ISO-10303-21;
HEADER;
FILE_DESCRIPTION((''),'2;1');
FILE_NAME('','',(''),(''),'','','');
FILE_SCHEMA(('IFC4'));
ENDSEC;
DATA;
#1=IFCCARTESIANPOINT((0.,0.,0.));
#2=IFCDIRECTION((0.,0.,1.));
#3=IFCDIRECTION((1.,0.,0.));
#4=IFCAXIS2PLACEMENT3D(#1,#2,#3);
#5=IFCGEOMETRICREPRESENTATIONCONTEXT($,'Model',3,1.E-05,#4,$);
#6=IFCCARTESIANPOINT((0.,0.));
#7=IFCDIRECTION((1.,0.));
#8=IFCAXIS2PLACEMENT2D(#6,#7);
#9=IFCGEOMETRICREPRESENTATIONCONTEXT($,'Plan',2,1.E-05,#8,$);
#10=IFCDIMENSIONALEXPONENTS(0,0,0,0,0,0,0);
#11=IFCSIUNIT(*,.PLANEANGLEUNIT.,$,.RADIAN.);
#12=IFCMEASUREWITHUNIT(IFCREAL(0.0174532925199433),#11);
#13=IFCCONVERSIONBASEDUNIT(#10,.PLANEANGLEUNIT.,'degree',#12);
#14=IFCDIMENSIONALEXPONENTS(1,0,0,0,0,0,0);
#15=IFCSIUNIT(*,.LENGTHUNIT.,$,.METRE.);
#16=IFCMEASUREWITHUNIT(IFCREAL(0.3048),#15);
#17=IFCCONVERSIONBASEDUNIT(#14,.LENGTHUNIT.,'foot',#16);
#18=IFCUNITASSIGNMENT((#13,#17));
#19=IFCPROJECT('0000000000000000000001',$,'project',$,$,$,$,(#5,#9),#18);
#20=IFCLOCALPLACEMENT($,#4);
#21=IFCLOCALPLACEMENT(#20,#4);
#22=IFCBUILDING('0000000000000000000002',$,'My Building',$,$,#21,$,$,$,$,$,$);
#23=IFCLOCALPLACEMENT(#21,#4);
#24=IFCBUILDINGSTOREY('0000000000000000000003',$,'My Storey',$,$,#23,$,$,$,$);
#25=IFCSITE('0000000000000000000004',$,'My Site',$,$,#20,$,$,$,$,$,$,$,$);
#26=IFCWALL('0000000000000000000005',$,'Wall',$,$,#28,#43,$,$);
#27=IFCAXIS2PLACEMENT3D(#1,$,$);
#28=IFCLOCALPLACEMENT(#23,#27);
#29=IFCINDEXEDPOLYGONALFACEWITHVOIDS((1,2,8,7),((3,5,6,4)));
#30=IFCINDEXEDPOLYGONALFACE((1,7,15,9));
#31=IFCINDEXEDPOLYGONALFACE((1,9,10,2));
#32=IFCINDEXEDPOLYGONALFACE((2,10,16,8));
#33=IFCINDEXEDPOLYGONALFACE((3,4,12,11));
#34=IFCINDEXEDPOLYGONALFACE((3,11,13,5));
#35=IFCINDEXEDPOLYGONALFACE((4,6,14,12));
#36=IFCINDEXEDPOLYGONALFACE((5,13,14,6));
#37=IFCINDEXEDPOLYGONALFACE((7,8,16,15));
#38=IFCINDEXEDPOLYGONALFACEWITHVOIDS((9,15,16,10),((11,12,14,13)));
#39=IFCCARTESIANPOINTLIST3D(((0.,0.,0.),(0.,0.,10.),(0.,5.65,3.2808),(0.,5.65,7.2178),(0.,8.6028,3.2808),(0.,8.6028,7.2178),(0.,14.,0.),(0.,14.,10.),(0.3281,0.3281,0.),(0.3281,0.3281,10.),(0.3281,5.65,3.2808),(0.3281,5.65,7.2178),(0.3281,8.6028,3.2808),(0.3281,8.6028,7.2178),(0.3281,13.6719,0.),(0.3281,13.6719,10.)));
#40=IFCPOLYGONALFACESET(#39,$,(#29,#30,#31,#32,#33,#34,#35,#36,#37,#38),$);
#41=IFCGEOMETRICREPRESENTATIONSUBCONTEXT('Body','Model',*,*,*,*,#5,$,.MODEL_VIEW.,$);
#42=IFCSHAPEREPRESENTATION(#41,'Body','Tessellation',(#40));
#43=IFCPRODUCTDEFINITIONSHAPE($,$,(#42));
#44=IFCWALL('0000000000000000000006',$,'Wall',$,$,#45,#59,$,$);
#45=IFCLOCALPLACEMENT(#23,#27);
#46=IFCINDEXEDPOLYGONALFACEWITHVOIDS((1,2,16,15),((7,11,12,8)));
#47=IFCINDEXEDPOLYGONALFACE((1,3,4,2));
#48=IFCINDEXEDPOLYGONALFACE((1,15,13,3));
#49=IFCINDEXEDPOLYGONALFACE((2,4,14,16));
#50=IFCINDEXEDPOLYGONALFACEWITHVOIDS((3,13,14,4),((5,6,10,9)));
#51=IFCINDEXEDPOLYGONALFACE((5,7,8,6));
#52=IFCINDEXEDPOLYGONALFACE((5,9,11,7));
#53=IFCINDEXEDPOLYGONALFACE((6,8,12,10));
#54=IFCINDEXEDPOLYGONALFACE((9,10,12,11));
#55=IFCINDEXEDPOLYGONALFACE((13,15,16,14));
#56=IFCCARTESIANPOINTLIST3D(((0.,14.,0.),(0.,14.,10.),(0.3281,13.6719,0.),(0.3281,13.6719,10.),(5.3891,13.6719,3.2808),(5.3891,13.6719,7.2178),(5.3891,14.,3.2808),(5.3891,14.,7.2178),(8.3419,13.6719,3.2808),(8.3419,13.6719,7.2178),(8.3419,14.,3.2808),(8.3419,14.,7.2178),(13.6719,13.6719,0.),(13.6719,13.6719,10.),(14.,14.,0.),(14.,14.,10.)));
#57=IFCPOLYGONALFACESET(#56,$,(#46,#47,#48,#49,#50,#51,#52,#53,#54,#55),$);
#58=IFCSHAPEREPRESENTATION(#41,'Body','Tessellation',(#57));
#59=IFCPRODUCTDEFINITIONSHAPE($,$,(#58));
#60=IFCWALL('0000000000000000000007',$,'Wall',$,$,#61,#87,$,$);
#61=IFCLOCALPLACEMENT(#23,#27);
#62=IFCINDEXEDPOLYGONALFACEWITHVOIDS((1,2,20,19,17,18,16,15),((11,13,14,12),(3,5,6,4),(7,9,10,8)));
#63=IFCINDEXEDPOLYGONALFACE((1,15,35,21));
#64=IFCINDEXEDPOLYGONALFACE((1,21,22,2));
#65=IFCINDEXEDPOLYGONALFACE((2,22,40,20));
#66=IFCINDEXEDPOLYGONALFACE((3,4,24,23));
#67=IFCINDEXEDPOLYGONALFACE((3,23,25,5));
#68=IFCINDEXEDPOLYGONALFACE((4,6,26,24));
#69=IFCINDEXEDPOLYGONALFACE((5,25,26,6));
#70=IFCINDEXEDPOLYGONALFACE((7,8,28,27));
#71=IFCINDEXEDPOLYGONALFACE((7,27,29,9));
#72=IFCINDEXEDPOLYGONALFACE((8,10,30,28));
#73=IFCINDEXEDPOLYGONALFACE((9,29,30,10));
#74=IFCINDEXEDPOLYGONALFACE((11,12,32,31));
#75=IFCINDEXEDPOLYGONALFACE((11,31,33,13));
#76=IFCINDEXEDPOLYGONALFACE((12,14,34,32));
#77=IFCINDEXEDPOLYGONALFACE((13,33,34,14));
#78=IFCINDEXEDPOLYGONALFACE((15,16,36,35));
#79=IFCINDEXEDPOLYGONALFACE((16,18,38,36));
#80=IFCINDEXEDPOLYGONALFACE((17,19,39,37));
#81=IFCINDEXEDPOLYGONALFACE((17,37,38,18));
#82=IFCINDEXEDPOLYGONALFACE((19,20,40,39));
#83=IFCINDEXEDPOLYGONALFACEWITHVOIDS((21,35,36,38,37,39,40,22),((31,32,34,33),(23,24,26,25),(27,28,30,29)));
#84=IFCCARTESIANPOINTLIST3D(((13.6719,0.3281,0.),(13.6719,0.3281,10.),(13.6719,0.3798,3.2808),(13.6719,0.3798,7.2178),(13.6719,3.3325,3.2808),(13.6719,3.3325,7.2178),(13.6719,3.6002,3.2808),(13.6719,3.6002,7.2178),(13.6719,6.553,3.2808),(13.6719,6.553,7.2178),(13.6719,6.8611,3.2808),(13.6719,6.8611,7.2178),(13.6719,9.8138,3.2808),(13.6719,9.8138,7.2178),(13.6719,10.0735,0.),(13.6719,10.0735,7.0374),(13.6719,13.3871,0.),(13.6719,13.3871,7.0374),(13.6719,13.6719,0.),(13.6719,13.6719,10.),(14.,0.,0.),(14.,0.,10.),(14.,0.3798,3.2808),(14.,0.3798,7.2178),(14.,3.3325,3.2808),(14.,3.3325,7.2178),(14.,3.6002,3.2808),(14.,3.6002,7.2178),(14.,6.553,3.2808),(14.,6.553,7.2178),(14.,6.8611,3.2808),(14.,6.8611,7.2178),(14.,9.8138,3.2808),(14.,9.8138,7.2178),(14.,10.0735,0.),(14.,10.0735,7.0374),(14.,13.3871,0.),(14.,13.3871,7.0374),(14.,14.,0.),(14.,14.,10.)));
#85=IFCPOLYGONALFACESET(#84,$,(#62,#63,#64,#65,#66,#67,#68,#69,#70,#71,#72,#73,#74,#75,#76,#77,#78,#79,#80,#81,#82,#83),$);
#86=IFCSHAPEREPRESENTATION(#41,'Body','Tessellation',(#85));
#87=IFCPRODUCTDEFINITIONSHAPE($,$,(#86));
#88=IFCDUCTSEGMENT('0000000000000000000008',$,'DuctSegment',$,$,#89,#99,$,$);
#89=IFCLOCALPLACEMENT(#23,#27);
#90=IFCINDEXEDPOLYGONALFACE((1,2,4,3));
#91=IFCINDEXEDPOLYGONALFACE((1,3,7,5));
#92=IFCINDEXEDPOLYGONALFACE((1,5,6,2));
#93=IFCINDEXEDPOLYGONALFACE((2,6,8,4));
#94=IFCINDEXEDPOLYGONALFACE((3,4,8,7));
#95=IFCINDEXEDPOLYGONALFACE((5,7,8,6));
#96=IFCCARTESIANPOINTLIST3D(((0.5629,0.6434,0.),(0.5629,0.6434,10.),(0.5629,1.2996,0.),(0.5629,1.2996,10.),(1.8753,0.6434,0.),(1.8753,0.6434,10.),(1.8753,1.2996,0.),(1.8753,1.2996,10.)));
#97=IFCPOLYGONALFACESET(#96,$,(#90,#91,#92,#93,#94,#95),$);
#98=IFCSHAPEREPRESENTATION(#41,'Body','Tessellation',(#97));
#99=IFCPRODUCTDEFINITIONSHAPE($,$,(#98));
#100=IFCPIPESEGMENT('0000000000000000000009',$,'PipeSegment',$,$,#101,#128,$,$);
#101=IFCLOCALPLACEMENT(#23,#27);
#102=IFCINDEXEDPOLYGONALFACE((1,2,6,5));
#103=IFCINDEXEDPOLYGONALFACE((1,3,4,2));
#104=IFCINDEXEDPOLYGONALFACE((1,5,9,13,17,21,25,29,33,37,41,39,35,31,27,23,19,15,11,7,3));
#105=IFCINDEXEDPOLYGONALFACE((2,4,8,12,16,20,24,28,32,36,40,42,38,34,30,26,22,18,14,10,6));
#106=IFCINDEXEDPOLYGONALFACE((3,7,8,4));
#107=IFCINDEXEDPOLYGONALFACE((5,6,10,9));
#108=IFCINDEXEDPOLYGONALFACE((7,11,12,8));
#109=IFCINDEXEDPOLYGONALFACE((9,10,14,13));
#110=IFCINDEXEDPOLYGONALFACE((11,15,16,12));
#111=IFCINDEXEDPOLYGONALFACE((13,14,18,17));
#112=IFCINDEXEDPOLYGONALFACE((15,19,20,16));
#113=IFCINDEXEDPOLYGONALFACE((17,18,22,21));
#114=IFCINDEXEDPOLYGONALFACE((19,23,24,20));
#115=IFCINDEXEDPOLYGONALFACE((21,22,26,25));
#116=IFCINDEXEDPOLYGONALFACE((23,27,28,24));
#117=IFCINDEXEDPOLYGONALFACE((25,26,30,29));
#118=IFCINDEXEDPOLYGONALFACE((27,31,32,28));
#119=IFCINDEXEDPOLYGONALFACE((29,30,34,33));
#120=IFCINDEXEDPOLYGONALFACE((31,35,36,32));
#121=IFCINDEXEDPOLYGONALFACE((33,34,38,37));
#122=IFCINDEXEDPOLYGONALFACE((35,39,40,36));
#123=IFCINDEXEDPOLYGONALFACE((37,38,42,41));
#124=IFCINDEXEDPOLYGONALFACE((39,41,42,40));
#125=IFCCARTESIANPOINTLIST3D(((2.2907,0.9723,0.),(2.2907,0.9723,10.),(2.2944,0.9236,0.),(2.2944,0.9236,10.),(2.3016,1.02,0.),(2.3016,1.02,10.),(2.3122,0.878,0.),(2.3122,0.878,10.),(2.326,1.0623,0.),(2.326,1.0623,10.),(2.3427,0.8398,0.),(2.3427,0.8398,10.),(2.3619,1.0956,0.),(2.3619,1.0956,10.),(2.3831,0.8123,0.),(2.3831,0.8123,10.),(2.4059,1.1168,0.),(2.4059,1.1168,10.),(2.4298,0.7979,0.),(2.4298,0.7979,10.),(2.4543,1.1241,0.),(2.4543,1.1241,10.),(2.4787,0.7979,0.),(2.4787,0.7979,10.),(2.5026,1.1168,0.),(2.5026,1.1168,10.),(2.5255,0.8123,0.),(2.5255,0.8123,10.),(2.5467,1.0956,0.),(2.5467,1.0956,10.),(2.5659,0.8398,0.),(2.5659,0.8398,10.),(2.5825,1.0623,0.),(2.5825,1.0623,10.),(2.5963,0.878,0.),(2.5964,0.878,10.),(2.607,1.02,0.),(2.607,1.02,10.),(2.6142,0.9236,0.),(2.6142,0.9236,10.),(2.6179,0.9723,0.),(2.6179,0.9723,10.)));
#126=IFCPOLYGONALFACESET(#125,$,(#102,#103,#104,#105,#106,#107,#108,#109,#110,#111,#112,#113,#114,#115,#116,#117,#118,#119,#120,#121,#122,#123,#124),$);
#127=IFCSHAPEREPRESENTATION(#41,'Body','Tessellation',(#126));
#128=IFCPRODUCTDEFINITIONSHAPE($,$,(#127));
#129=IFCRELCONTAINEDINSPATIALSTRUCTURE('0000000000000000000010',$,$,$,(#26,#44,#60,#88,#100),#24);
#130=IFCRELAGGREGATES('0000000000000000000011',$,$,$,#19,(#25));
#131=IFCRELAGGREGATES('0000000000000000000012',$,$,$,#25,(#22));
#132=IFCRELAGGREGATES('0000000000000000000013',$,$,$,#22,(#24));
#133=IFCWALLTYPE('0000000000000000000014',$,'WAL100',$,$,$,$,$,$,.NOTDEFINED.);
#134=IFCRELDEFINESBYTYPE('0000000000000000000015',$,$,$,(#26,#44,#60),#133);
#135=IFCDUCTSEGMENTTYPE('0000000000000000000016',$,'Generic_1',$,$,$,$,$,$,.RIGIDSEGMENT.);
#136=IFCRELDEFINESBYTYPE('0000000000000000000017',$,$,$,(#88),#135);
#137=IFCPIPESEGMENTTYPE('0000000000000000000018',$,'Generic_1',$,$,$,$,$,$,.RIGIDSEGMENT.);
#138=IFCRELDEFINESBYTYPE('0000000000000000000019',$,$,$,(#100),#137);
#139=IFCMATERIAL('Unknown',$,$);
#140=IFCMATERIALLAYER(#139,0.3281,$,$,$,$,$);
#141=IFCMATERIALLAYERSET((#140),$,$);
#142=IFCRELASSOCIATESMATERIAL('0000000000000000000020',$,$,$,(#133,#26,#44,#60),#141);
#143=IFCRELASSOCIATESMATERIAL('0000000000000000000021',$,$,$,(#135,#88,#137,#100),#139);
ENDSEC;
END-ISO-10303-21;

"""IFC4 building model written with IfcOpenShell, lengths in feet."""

from ifc_helpers import new_model, entity, si_unit, converted_unit, frame, origin_with_axes, origin_2d_with_axis, place, context, subcontext, project, spatial, line, indexed_curve, rectangle, circle, outline, extrude, clip, halfspace, source, transform, mapped, material, layer, layer_set, layer_usage, material_profile, profile_set, profile_usage, type_object, element, save


model = new_model("IFC4")

# Units and contexts
model_context = context("Model", 3, precision=1e-05, world=origin_with_axes())
plan_context = context("Plan", 2, precision=1e-05, world=origin_2d_with_axis())
body_context_1 = subcontext(model_context, "Body", "Model", "MODEL_VIEW")
ifc_project = project(units=[converted_unit("PLANEANGLEUNIT", "degree", entity("IfcReal", 0.0174532925199433), si_unit("PLANEANGLEUNIT", "RADIAN"), dimensions=[0, 0, 0, 0, 0, 0, 0]), converted_unit("LENGTHUNIT", "foot", entity("IfcReal", 0.3048), si_unit("LENGTHUNIT", "METRE"), dimensions=[1, 0, 0, 0, 0, 0, 0])], contexts=[model_context, plan_context])

# Site, building, storey
site_placement = place(None, origin_with_axes())
site = spatial("IfcSite", under=ifc_project, at=site_placement, Name="My Site")
building_placement = place(site_placement, origin_with_axes())
building = spatial("IfcBuilding", under=site, at=building_placement, Name="My Building")
storey_placement = place(building_placement, origin_with_axes())
storey = spatial("IfcBuildingStorey", under=building, at=storey_placement, Name="My Storey")

# Shared definitions
ifc_material = material(Name="Unknown")

# Walls, openings
ifc_layer_1 = layer(ifc_material, 0.3281)
ifc_layer_set_1 = layer_set([ifc_layer_1])
wall_type = type_object("IfcWallType", Name="WAL100", PredefinedType="NOTDEFINED", material=ifc_layer_set_1)
shared_shape_1 = source(origin_with_axes(), body_context_1, "Body", "SweptSolid", [
    extrude(outline(indexed_curve([(0.0, 0.0), (2.9528, 0.0), (2.9528, 3.937), (0.0, 3.937)], segments=[line(1, 2, 3, 4, 1)])), frame((0.0, -1.9685, 0.0), z_axis=(0.0, -1.0, 0.0), x_axis=(1.0, 0.0, 0.0)), (0.0, 0.0, -1.0), 3.937),
])
ifc_layer_usage_1 = layer_usage(ifc_layer_set_1, "AXIS2", "POSITIVE", 0.0)
wall_1_placement = place(storey_placement, frame((0.0, 14.0, 0.0), z_axis=(0.0, 0.0, 1.0), x_axis=(0.0, -1.0, 0.0)))
wall_1 = element("IfcWall", 1, at=wall_1_placement, inside=storey, type_object=wall_type, material=ifc_layer_usage_1, Name="Wall", context=body_context_1, shape_type="Clipping", body=[
    clip(clip(extrude(outline(indexed_curve([(0.0, 0.0), (0.0, 0.3281), (14.0, 0.3281), (14.0, 0.0), (0.0, 0.0)], self_intersect=False)), origin_with_axes(), (0.0, 0.0, 1.0), 10.0), halfspace(frame((14.0, 0.0, 0.0), z_axis=(0.707107, 0.707107, 0.0), x_axis=(0.707107, -0.707107, 0.0)), False)), halfspace(frame((0.0, 0.0, 0.0), z_axis=(-0.707107, 0.707107, 0.0), x_axis=(0.707107, 0.707107, 0.0)), False)),
])
opening_1_placement = place(wall_1_placement, frame((5.3972, 0.0, 3.2808), z_axis=(0.0, 0.0, 1.0), x_axis=(1.0, 0.0, 0.0)))
element("IfcOpeningElement", 2, at=opening_1_placement, cuts=wall_1, PredefinedType="OPENING", context=body_context_1, shape_type="MappedRepresentation", body=[
    mapped(shared_shape_1, transform((0.0, 0.0, 0.0), x_axis=(1.0, 0.0, 0.0), y_axis=(0.0, 1.0, 0.0), z_axis=(0.0, 0.0, 1.0), scale=1.0)),
])
ifc_layer_usage_2 = layer_usage(ifc_layer_set_1, "AXIS2", "POSITIVE", 0.0)
wall_2_placement = place(storey_placement, frame((14.0, 14.0, 0.0), z_axis=(0.0, 0.0, 1.0), x_axis=(-1.0, 0.0, 0.0)))
wall_2 = element("IfcWall", 3, at=wall_2_placement, inside=storey, type_object=wall_type, material=ifc_layer_usage_2, Name="Wall", context=body_context_1, shape_type="Clipping", body=[
    clip(clip(extrude(outline(indexed_curve([(0.0, 0.0), (0.0, 0.3281), (14.0, 0.3281), (14.0, 0.0), (0.0, 0.0)], self_intersect=False)), origin_with_axes(), (0.0, 0.0, 1.0), 10.0), halfspace(frame((14.0, 0.0, 0.0), z_axis=(0.707107, 0.707107, 0.0), x_axis=(0.707107, -0.707107, 0.0)), False)), halfspace(frame((0.0, 0.0, 0.0), z_axis=(-0.707106, 0.707107, 0.0), x_axis=(0.707107, 0.707106, 0.0)), False)),
])
opening_2_placement = place(wall_2_placement, frame((5.6581, 0.0, 3.2808), z_axis=(0.0, 0.0, 1.0), x_axis=(1.0, 0.0, 0.0)))
element("IfcOpeningElement", 4, at=opening_2_placement, cuts=wall_2, PredefinedType="OPENING", context=body_context_1, shape_type="MappedRepresentation", body=[
    mapped(shared_shape_1, transform((0.0, 0.0, 0.0), x_axis=(1.0, 0.0, 0.0), y_axis=(0.0, 1.0, 0.0), z_axis=(0.0, 0.0, 1.0), scale=1.0)),
])

# Wall, openings
ifc_layer_usage_3 = layer_usage(ifc_layer_set_1, "AXIS2", "POSITIVE", 0.0)
wall_3_placement = place(storey_placement, frame((14.0, 0.0, 0.0), z_axis=(0.0, 0.0, 1.0), x_axis=(0.0, 1.0, 0.0)))
wall_3 = element("IfcWall", 5, at=wall_3_placement, inside=storey, type_object=wall_type, material=ifc_layer_usage_3, Name="Wall", context=body_context_1, shape_type="Clipping", body=[
    clip(clip(extrude(outline(indexed_curve([(0.0, 0.0), (0.0, 0.3281), (14.0, 0.3281), (14.0, 0.0), (0.0, 0.0)], self_intersect=False)), origin_with_axes(), (0.0, 0.0, 1.0), 10.0), halfspace(frame((14.0, 0.0, 0.0), z_axis=(0.707106, 0.707107, 0.0), x_axis=(0.707107, -0.707107, 0.0)), False)), halfspace(frame((0.0, 0.0, 0.0), z_axis=(-0.707107, 0.707107, 0.0), x_axis=(0.707107, 0.707107, 0.0)), False)),
])
shared_shape_2 = source(origin_with_axes(), body_context_1, "Body", "SweptSolid", [
    extrude(outline(indexed_curve([(0.0, 0.0), (3.3136, 0.0), (3.3136, 7.0374), (0.0, 7.0374)], segments=[line(1, 2, 3, 4, 1)])), frame((0.0, -1.9685, 0.0), z_axis=(0.0, -1.0, 0.0), x_axis=(1.0, 0.0, 0.0)), (0.0, 0.0, -1.0), 3.937),
])
opening_3_placement = place(wall_3_placement, frame((10.0735, 0.0, 0.0), z_axis=(0.0, 0.0, 1.0), x_axis=(1.0, 0.0, 0.0)))
element("IfcOpeningElement", 6, at=opening_3_placement, cuts=wall_3, PredefinedType="OPENING", context=body_context_1, shape_type="MappedRepresentation", body=[
    mapped(shared_shape_2, transform((0.0, 0.0, 0.0), x_axis=(1.0, 0.0, 0.0), y_axis=(0.0, 1.0, 0.0), z_axis=(0.0, 0.0, 1.0), scale=1.0)),
])
opening_4_placement = place(wall_3_placement, frame((0.3798, 0.0, 3.2808), z_axis=(0.0, 0.0, 1.0), x_axis=(1.0, 0.0, 0.0)))
element("IfcOpeningElement", 7, at=opening_4_placement, cuts=wall_3, PredefinedType="OPENING", context=body_context_1, shape_type="MappedRepresentation", body=[
    mapped(shared_shape_1, transform((0.0, 0.0, 0.0), x_axis=(1.0, 0.0, 0.0), y_axis=(0.0, 1.0, 0.0), z_axis=(0.0, 0.0, 1.0), scale=1.0)),
])
opening_5_placement = place(wall_3_placement, frame((3.6002, 0.0, 3.2808), z_axis=(0.0, 0.0, 1.0), x_axis=(1.0, 0.0, 0.0)))
element("IfcOpeningElement", 8, at=opening_5_placement, cuts=wall_3, PredefinedType="OPENING", context=body_context_1, shape_type="MappedRepresentation", body=[
    mapped(shared_shape_1, transform((0.0, 0.0, 0.0), x_axis=(1.0, 0.0, 0.0), y_axis=(0.0, 1.0, 0.0), z_axis=(0.0, 0.0, 1.0), scale=1.0)),
])
opening_6_placement = place(wall_3_placement, frame((6.861, 0.0, 3.2808), z_axis=(0.0, 0.0, 1.0), x_axis=(1.0, 0.0, 0.0)))
element("IfcOpeningElement", 9, at=opening_6_placement, cuts=wall_3, PredefinedType="OPENING", context=body_context_1, shape_type="MappedRepresentation", body=[
    mapped(shared_shape_1, transform((0.0, 0.0, 0.0), x_axis=(1.0, 0.0, 0.0), y_axis=(0.0, 1.0, 0.0), z_axis=(0.0, 0.0, 1.0), scale=1.0)),
])

# Duct segment
ifc_material_profile_1 = material_profile(ifc_material, rectangle(XDim=1.3123, YDim=0.6562))
ifc_profile_set_1 = profile_set([ifc_material_profile_1])
ifc_profile_usage_1 = profile_usage(ifc_profile_set_1, cardinal=5)
duct_segment_type = type_object("IfcDuctSegmentType", Name="Generic_1", PredefinedType="RIGIDSEGMENT", material=ifc_profile_set_1)
duct_segment_placement = place(storey_placement, frame((1.2191, 0.9715, 0.0), z_axis=(0.0, 0.0, 1.0), x_axis=(-1.0, 0.0, 0.0)))
element("IfcDuctSegment", 10, at=duct_segment_placement, inside=storey, type_object=duct_segment_type, material=ifc_profile_usage_1, Name="DuctSegment", context=body_context_1, shape_type="SweptSolid", body=[
    extrude(rectangle(XDim=1.3123, YDim=0.6562), origin_with_axes(), (0.0, 0.0, 1.0), 10.0),
])

# Pipe segment
ifc_material_profile_2 = material_profile(ifc_material, circle(Radius=0.164))
ifc_profile_set_2 = profile_set([ifc_material_profile_2])
ifc_profile_usage_2 = profile_usage(ifc_profile_set_2, cardinal=5)
pipe_segment_type = type_object("IfcPipeSegmentType", Name="Generic_1", PredefinedType="RIGIDSEGMENT", material=ifc_profile_set_2)
pipe_segment_placement = place(storey_placement, frame((2.4543, 0.9601, 0.0), z_axis=(0.0, 0.0, 1.0), x_axis=(0.0, 1.0, 0.0)))
element("IfcPipeSegment", 11, at=pipe_segment_placement, inside=storey, type_object=pipe_segment_type, material=ifc_profile_usage_2, Name="PipeSegment", context=body_context_1, shape_type="SweptSolid", body=[
    extrude(circle(Radius=0.164), origin_with_axes(), (0.0, 0.0, 1.0), 10.0),
])

save(model, "model.ifc")
